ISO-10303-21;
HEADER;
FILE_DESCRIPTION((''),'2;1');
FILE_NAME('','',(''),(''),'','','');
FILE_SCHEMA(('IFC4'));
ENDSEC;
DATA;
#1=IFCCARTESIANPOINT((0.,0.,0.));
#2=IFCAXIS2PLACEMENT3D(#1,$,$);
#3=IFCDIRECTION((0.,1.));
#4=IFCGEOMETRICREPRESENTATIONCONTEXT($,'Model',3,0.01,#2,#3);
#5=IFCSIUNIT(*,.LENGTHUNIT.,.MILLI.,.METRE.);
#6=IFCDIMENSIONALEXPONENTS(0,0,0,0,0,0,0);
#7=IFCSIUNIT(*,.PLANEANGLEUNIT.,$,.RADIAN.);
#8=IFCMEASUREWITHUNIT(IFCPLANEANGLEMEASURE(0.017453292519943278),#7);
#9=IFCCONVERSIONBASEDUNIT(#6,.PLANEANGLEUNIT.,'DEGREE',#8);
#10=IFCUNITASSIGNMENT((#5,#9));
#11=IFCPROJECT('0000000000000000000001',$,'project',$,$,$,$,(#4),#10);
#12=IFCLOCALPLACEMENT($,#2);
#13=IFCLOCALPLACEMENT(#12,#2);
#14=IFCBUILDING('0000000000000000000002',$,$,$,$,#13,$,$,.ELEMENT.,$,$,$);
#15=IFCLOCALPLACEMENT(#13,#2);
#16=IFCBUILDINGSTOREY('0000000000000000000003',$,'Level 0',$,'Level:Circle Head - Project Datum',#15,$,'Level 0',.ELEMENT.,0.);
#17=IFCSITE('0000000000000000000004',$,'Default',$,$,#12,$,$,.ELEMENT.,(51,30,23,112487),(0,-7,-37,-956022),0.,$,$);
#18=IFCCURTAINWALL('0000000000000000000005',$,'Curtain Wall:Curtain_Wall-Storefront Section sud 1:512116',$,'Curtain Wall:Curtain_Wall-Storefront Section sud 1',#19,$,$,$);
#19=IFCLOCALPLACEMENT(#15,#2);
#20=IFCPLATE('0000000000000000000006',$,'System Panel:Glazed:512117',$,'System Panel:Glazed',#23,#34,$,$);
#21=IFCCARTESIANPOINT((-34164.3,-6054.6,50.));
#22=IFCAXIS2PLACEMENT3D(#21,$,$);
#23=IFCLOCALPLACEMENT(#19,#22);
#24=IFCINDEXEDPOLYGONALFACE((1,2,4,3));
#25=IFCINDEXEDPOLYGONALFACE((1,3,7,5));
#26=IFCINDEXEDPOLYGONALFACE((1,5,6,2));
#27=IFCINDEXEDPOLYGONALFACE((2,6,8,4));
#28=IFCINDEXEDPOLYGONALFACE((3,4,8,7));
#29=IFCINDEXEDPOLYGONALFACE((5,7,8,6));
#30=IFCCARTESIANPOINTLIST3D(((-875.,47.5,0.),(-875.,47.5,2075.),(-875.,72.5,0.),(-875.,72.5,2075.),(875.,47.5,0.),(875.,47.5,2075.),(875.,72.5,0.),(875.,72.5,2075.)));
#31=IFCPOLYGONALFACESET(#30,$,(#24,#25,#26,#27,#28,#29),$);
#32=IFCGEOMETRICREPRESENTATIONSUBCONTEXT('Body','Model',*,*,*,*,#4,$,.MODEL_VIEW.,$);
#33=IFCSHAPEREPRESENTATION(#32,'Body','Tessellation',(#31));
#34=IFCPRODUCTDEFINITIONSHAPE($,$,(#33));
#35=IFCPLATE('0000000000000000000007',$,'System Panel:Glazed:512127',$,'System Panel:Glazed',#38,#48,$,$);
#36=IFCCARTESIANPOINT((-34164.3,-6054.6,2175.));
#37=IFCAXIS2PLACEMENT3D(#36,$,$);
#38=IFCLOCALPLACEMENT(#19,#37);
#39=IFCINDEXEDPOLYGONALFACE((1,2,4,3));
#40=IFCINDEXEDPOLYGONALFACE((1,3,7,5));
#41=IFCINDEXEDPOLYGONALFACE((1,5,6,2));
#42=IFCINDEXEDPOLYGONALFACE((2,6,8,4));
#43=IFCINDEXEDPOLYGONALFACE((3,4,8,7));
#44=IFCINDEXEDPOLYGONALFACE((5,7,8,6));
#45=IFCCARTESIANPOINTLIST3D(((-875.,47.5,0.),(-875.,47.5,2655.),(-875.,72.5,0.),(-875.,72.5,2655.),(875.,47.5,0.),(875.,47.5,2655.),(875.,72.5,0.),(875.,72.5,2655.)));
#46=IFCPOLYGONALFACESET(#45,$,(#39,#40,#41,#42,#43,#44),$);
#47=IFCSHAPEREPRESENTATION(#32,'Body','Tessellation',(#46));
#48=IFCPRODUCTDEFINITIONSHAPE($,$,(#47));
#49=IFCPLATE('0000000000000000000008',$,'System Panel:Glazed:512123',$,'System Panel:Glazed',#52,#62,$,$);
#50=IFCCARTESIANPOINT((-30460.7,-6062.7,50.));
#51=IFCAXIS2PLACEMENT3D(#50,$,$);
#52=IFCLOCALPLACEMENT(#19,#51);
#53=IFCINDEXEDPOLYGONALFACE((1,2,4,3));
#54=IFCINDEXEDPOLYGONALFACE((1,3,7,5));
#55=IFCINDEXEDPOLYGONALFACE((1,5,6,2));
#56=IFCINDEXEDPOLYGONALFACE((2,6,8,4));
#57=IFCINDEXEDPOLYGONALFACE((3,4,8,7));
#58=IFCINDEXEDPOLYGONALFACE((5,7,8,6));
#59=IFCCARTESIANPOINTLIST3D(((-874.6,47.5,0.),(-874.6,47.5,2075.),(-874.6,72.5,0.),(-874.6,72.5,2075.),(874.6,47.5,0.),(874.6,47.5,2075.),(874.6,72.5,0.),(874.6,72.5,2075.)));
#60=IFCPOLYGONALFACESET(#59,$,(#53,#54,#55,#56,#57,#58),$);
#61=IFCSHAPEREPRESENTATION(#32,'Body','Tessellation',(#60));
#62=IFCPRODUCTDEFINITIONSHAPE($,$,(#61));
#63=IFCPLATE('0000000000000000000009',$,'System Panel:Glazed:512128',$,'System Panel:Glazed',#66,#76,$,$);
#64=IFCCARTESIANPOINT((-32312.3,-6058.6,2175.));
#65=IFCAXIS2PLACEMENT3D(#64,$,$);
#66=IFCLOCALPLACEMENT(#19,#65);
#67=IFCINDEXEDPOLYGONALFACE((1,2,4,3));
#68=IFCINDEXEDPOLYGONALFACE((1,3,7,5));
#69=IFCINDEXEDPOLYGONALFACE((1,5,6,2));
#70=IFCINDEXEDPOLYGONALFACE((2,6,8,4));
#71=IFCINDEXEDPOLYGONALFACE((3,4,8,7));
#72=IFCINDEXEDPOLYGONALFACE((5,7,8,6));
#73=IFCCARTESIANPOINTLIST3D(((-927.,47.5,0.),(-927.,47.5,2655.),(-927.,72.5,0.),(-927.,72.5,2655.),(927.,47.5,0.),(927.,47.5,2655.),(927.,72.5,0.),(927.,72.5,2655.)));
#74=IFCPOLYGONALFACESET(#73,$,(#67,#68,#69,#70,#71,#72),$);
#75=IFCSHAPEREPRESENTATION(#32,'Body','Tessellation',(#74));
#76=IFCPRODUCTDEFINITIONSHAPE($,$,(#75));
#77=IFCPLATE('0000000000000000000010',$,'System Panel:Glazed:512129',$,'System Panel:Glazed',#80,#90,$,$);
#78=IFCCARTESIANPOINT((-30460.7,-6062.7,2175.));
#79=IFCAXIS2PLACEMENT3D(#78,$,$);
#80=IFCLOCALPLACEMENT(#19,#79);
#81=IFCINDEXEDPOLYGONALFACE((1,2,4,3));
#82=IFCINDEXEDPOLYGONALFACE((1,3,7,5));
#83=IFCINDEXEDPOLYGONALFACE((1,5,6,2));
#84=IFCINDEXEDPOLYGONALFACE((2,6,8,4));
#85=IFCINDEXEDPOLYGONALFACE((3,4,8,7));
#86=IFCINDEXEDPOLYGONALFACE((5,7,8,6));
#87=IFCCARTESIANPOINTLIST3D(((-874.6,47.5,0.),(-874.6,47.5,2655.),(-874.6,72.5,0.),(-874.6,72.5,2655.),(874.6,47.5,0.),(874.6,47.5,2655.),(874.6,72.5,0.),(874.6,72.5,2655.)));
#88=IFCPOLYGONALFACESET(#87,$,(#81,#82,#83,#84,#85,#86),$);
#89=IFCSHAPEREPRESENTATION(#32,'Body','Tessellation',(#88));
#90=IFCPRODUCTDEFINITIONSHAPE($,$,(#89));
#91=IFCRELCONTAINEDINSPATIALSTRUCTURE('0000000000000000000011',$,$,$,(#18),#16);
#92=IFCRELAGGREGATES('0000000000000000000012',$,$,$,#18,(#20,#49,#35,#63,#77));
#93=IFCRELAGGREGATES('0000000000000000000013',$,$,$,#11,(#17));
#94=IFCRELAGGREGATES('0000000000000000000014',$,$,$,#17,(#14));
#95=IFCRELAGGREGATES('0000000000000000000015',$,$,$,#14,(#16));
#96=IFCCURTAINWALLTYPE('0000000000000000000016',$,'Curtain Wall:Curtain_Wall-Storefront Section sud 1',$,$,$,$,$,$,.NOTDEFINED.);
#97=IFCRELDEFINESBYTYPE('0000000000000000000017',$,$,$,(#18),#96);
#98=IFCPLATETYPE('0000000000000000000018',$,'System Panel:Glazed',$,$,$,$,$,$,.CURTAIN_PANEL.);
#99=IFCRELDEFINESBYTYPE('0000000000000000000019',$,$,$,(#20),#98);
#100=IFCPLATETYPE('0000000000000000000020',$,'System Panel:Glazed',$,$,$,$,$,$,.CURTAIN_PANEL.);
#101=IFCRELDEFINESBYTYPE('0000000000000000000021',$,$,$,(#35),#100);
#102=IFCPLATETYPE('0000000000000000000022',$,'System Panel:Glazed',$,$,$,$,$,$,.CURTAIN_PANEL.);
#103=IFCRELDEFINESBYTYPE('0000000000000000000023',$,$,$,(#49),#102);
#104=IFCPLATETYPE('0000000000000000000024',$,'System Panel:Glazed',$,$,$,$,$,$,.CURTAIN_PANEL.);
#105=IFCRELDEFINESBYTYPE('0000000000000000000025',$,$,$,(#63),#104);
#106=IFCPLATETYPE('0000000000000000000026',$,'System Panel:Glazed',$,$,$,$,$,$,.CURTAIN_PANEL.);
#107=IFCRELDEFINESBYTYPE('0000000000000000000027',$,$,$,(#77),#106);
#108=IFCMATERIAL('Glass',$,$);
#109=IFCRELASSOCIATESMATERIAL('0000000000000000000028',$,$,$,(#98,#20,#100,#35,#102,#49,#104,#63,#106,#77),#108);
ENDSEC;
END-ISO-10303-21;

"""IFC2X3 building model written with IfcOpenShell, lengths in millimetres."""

from ifc_helpers import new_model, entity, si_unit, converted_unit, direction, frame, frame_2d, origin, origin_2d_with_axis, place, context, subcontext, project, spatial, rectangle, extrude, source, transform, mapped, material, type_object, type_shapes, element, aggregate, save


model = new_model("IFC2X3")

# Units and contexts
model_context = context("Model", 3, precision=0.01, world=origin(), true_north=direction((0.0, 1.0)))
body_context = subcontext(model_context, "Body", "Model", "MODEL_VIEW")
ifc_project = project(units=[si_unit("LENGTHUNIT", "METRE", prefix="MILLI"), converted_unit("PLANEANGLEUNIT", "DEGREE", entity("IfcPlaneAngleMeasure", 0.017453292519943278), si_unit("PLANEANGLEUNIT", "RADIAN"), dimensions=[0, 0, 0, 0, 0, 0, 0])], contexts=[model_context])

# Site, building, storey
site_placement = place(None, origin())
site = spatial("IfcSite", under=ifc_project, at=site_placement, Name="Default", CompositionType="ELEMENT", RefLatitude=(51, 30, 23, 112487), RefLongitude=(0, -7, -37, -956022), RefElevation=0.0)
building_placement = place(site_placement, origin())
building = spatial("IfcBuilding", under=site, at=building_placement, CompositionType="ELEMENT")
storey_placement = place(building_placement, origin())
storey = spatial("IfcBuildingStorey", under=building, at=storey_placement, Name="Level 0", ObjectType="Level:Circle Head - Project Datum", LongName="Level 0", CompositionType="ELEMENT", Elevation=0.0)

# Curtain wall, plates
curtain_wall_type = type_object("IfcCurtainWallType", Name="Curtain Wall:Curtain_Wall-Storefront Section sud 1", PredefinedType="NOTDEFINED")
curtain_wall_placement = place(storey_placement, origin())
curtain_wall = element("IfcCurtainWall", 1, at=curtain_wall_placement, inside=storey, type_object=curtain_wall_type, Name="Curtain Wall:Curtain_Wall-Storefront Section sud 1:512116", ObjectType="Curtain Wall:Curtain_Wall-Storefront Section sud 1")
ifc_material_1 = material(Name="Glass")
plate_type_1 = type_object("IfcPlateType", Name="System Panel:Glazed", PredefinedType="CURTAIN_PANEL", material=ifc_material_1)
shared_shape_1 = source(origin(), body_context, "Body", "SweptSolid", [
    extrude(rectangle(XDim=25.0, YDim=1750.0, at=origin_2d_with_axis()), frame((0.0, 60.0, 0.0), z_axis=(0.0, 0.0, 1.0), x_axis=(0.0, 1.0, 0.0)), (0.0, 0.0, 1.0), 2075.0),
])
type_shapes(plate_type_1, [shared_shape_1])
plate_1_placement = place(curtain_wall_placement, frame((-34164.3, -6054.6, 50.0)))
plate_1 = element("IfcPlate", 2, at=plate_1_placement, type_object=plate_type_1, material=ifc_material_1, Name="System Panel:Glazed:512117", ObjectType="System Panel:Glazed", context=body_context, shape_type="MappedRepresentation", body=[
    mapped(shared_shape_1, transform((0.0, 0.0, 0.0), scale=1.0)),
])
plate_type_2 = type_object("IfcPlateType", Name="System Panel:Glazed", PredefinedType="CURTAIN_PANEL", material=ifc_material_1)
shared_shape_2 = source(origin(), body_context, "Body", "SweptSolid", [
    extrude(rectangle(XDim=25.0, YDim=1750.0, at=frame_2d((0.0, 0.0), x_axis=(1.0, 0.0))), frame((0.0, 60.0, 0.0), z_axis=(0.0, 0.0, 1.0), x_axis=(0.0, 1.0, 0.0)), (0.0, 0.0, 1.0), 2655.0),
])
type_shapes(plate_type_2, [shared_shape_2])
plate_2_placement = place(curtain_wall_placement, frame((-34164.3, -6054.6, 2175.0)))
plate_2 = element("IfcPlate", 3, at=plate_2_placement, type_object=plate_type_2, material=ifc_material_1, Name="System Panel:Glazed:512127", ObjectType="System Panel:Glazed", context=body_context, shape_type="MappedRepresentation", body=[
    mapped(shared_shape_2, transform((0.0, 0.0, 0.0), scale=1.0)),
])
plate_type_3 = type_object("IfcPlateType", Name="System Panel:Glazed", PredefinedType="CURTAIN_PANEL", material=ifc_material_1)
shared_shape_3 = source(origin(), body_context, "Body", "SweptSolid", [
    extrude(rectangle(XDim=25.0, YDim=1749.2, at=origin_2d_with_axis()), frame((0.0, 60.0, 0.0), z_axis=(0.0, 0.0, 1.0), x_axis=(0.0, 1.0, 0.0)), (0.0, 0.0, 1.0), 2075.0),
])
type_shapes(plate_type_3, [shared_shape_3])
plate_3_placement = place(curtain_wall_placement, frame((-30460.7, -6062.7, 50.0)))
plate_3 = element("IfcPlate", 4, at=plate_3_placement, type_object=plate_type_3, material=ifc_material_1, Name="System Panel:Glazed:512123", ObjectType="System Panel:Glazed", context=body_context, shape_type="MappedRepresentation", body=[
    mapped(shared_shape_3, transform((0.0, 0.0, 0.0), scale=1.0)),
])
plate_type_4 = type_object("IfcPlateType", Name="System Panel:Glazed", PredefinedType="CURTAIN_PANEL", material=ifc_material_1)
shared_shape_4 = source(origin(), body_context, "Body", "SweptSolid", [
    extrude(rectangle(XDim=25.0, YDim=1854.0, at=frame_2d((0.0, 0.0), x_axis=(1.0, 0.0))), frame((0.0, 60.0, 0.0), z_axis=(0.0, 0.0, 1.0), x_axis=(0.0, 1.0, 0.0)), (0.0, 0.0, 1.0), 2655.0),
])
type_shapes(plate_type_4, [shared_shape_4])
plate_4_placement = place(curtain_wall_placement, frame((-32312.3, -6058.6, 2175.0)))
plate_4 = element("IfcPlate", 5, at=plate_4_placement, type_object=plate_type_4, material=ifc_material_1, Name="System Panel:Glazed:512128", ObjectType="System Panel:Glazed", context=body_context, shape_type="MappedRepresentation", body=[
    mapped(shared_shape_4, transform((0.0, 0.0, 0.0), scale=1.0)),
])
plate_type_5 = type_object("IfcPlateType", Name="System Panel:Glazed", PredefinedType="CURTAIN_PANEL", material=ifc_material_1)
shared_shape_5 = source(origin(), body_context, "Body", "SweptSolid", [
    extrude(rectangle(XDim=25.0, YDim=1749.2, at=frame_2d((0.0, 0.0), x_axis=(1.0, 0.0))), frame((0.0, 60.0, 0.0), z_axis=(0.0, 0.0, 1.0), x_axis=(0.0, 1.0, 0.0)), (0.0, 0.0, 1.0), 2655.0),
])
type_shapes(plate_type_5, [shared_shape_5])
plate_5_placement = place(curtain_wall_placement, frame((-30460.7, -6062.7, 2175.0)))
plate_5 = element("IfcPlate", 6, at=plate_5_placement, type_object=plate_type_5, material=ifc_material_1, Name="System Panel:Glazed:512129", ObjectType="System Panel:Glazed", context=body_context, shape_type="MappedRepresentation", body=[
    mapped(shared_shape_5, transform((0.0, 0.0, 0.0), scale=1.0)),
])
aggregate(curtain_wall, [plate_1, plate_3, plate_2, plate_4, plate_5])

save(model, "model.ifc")
